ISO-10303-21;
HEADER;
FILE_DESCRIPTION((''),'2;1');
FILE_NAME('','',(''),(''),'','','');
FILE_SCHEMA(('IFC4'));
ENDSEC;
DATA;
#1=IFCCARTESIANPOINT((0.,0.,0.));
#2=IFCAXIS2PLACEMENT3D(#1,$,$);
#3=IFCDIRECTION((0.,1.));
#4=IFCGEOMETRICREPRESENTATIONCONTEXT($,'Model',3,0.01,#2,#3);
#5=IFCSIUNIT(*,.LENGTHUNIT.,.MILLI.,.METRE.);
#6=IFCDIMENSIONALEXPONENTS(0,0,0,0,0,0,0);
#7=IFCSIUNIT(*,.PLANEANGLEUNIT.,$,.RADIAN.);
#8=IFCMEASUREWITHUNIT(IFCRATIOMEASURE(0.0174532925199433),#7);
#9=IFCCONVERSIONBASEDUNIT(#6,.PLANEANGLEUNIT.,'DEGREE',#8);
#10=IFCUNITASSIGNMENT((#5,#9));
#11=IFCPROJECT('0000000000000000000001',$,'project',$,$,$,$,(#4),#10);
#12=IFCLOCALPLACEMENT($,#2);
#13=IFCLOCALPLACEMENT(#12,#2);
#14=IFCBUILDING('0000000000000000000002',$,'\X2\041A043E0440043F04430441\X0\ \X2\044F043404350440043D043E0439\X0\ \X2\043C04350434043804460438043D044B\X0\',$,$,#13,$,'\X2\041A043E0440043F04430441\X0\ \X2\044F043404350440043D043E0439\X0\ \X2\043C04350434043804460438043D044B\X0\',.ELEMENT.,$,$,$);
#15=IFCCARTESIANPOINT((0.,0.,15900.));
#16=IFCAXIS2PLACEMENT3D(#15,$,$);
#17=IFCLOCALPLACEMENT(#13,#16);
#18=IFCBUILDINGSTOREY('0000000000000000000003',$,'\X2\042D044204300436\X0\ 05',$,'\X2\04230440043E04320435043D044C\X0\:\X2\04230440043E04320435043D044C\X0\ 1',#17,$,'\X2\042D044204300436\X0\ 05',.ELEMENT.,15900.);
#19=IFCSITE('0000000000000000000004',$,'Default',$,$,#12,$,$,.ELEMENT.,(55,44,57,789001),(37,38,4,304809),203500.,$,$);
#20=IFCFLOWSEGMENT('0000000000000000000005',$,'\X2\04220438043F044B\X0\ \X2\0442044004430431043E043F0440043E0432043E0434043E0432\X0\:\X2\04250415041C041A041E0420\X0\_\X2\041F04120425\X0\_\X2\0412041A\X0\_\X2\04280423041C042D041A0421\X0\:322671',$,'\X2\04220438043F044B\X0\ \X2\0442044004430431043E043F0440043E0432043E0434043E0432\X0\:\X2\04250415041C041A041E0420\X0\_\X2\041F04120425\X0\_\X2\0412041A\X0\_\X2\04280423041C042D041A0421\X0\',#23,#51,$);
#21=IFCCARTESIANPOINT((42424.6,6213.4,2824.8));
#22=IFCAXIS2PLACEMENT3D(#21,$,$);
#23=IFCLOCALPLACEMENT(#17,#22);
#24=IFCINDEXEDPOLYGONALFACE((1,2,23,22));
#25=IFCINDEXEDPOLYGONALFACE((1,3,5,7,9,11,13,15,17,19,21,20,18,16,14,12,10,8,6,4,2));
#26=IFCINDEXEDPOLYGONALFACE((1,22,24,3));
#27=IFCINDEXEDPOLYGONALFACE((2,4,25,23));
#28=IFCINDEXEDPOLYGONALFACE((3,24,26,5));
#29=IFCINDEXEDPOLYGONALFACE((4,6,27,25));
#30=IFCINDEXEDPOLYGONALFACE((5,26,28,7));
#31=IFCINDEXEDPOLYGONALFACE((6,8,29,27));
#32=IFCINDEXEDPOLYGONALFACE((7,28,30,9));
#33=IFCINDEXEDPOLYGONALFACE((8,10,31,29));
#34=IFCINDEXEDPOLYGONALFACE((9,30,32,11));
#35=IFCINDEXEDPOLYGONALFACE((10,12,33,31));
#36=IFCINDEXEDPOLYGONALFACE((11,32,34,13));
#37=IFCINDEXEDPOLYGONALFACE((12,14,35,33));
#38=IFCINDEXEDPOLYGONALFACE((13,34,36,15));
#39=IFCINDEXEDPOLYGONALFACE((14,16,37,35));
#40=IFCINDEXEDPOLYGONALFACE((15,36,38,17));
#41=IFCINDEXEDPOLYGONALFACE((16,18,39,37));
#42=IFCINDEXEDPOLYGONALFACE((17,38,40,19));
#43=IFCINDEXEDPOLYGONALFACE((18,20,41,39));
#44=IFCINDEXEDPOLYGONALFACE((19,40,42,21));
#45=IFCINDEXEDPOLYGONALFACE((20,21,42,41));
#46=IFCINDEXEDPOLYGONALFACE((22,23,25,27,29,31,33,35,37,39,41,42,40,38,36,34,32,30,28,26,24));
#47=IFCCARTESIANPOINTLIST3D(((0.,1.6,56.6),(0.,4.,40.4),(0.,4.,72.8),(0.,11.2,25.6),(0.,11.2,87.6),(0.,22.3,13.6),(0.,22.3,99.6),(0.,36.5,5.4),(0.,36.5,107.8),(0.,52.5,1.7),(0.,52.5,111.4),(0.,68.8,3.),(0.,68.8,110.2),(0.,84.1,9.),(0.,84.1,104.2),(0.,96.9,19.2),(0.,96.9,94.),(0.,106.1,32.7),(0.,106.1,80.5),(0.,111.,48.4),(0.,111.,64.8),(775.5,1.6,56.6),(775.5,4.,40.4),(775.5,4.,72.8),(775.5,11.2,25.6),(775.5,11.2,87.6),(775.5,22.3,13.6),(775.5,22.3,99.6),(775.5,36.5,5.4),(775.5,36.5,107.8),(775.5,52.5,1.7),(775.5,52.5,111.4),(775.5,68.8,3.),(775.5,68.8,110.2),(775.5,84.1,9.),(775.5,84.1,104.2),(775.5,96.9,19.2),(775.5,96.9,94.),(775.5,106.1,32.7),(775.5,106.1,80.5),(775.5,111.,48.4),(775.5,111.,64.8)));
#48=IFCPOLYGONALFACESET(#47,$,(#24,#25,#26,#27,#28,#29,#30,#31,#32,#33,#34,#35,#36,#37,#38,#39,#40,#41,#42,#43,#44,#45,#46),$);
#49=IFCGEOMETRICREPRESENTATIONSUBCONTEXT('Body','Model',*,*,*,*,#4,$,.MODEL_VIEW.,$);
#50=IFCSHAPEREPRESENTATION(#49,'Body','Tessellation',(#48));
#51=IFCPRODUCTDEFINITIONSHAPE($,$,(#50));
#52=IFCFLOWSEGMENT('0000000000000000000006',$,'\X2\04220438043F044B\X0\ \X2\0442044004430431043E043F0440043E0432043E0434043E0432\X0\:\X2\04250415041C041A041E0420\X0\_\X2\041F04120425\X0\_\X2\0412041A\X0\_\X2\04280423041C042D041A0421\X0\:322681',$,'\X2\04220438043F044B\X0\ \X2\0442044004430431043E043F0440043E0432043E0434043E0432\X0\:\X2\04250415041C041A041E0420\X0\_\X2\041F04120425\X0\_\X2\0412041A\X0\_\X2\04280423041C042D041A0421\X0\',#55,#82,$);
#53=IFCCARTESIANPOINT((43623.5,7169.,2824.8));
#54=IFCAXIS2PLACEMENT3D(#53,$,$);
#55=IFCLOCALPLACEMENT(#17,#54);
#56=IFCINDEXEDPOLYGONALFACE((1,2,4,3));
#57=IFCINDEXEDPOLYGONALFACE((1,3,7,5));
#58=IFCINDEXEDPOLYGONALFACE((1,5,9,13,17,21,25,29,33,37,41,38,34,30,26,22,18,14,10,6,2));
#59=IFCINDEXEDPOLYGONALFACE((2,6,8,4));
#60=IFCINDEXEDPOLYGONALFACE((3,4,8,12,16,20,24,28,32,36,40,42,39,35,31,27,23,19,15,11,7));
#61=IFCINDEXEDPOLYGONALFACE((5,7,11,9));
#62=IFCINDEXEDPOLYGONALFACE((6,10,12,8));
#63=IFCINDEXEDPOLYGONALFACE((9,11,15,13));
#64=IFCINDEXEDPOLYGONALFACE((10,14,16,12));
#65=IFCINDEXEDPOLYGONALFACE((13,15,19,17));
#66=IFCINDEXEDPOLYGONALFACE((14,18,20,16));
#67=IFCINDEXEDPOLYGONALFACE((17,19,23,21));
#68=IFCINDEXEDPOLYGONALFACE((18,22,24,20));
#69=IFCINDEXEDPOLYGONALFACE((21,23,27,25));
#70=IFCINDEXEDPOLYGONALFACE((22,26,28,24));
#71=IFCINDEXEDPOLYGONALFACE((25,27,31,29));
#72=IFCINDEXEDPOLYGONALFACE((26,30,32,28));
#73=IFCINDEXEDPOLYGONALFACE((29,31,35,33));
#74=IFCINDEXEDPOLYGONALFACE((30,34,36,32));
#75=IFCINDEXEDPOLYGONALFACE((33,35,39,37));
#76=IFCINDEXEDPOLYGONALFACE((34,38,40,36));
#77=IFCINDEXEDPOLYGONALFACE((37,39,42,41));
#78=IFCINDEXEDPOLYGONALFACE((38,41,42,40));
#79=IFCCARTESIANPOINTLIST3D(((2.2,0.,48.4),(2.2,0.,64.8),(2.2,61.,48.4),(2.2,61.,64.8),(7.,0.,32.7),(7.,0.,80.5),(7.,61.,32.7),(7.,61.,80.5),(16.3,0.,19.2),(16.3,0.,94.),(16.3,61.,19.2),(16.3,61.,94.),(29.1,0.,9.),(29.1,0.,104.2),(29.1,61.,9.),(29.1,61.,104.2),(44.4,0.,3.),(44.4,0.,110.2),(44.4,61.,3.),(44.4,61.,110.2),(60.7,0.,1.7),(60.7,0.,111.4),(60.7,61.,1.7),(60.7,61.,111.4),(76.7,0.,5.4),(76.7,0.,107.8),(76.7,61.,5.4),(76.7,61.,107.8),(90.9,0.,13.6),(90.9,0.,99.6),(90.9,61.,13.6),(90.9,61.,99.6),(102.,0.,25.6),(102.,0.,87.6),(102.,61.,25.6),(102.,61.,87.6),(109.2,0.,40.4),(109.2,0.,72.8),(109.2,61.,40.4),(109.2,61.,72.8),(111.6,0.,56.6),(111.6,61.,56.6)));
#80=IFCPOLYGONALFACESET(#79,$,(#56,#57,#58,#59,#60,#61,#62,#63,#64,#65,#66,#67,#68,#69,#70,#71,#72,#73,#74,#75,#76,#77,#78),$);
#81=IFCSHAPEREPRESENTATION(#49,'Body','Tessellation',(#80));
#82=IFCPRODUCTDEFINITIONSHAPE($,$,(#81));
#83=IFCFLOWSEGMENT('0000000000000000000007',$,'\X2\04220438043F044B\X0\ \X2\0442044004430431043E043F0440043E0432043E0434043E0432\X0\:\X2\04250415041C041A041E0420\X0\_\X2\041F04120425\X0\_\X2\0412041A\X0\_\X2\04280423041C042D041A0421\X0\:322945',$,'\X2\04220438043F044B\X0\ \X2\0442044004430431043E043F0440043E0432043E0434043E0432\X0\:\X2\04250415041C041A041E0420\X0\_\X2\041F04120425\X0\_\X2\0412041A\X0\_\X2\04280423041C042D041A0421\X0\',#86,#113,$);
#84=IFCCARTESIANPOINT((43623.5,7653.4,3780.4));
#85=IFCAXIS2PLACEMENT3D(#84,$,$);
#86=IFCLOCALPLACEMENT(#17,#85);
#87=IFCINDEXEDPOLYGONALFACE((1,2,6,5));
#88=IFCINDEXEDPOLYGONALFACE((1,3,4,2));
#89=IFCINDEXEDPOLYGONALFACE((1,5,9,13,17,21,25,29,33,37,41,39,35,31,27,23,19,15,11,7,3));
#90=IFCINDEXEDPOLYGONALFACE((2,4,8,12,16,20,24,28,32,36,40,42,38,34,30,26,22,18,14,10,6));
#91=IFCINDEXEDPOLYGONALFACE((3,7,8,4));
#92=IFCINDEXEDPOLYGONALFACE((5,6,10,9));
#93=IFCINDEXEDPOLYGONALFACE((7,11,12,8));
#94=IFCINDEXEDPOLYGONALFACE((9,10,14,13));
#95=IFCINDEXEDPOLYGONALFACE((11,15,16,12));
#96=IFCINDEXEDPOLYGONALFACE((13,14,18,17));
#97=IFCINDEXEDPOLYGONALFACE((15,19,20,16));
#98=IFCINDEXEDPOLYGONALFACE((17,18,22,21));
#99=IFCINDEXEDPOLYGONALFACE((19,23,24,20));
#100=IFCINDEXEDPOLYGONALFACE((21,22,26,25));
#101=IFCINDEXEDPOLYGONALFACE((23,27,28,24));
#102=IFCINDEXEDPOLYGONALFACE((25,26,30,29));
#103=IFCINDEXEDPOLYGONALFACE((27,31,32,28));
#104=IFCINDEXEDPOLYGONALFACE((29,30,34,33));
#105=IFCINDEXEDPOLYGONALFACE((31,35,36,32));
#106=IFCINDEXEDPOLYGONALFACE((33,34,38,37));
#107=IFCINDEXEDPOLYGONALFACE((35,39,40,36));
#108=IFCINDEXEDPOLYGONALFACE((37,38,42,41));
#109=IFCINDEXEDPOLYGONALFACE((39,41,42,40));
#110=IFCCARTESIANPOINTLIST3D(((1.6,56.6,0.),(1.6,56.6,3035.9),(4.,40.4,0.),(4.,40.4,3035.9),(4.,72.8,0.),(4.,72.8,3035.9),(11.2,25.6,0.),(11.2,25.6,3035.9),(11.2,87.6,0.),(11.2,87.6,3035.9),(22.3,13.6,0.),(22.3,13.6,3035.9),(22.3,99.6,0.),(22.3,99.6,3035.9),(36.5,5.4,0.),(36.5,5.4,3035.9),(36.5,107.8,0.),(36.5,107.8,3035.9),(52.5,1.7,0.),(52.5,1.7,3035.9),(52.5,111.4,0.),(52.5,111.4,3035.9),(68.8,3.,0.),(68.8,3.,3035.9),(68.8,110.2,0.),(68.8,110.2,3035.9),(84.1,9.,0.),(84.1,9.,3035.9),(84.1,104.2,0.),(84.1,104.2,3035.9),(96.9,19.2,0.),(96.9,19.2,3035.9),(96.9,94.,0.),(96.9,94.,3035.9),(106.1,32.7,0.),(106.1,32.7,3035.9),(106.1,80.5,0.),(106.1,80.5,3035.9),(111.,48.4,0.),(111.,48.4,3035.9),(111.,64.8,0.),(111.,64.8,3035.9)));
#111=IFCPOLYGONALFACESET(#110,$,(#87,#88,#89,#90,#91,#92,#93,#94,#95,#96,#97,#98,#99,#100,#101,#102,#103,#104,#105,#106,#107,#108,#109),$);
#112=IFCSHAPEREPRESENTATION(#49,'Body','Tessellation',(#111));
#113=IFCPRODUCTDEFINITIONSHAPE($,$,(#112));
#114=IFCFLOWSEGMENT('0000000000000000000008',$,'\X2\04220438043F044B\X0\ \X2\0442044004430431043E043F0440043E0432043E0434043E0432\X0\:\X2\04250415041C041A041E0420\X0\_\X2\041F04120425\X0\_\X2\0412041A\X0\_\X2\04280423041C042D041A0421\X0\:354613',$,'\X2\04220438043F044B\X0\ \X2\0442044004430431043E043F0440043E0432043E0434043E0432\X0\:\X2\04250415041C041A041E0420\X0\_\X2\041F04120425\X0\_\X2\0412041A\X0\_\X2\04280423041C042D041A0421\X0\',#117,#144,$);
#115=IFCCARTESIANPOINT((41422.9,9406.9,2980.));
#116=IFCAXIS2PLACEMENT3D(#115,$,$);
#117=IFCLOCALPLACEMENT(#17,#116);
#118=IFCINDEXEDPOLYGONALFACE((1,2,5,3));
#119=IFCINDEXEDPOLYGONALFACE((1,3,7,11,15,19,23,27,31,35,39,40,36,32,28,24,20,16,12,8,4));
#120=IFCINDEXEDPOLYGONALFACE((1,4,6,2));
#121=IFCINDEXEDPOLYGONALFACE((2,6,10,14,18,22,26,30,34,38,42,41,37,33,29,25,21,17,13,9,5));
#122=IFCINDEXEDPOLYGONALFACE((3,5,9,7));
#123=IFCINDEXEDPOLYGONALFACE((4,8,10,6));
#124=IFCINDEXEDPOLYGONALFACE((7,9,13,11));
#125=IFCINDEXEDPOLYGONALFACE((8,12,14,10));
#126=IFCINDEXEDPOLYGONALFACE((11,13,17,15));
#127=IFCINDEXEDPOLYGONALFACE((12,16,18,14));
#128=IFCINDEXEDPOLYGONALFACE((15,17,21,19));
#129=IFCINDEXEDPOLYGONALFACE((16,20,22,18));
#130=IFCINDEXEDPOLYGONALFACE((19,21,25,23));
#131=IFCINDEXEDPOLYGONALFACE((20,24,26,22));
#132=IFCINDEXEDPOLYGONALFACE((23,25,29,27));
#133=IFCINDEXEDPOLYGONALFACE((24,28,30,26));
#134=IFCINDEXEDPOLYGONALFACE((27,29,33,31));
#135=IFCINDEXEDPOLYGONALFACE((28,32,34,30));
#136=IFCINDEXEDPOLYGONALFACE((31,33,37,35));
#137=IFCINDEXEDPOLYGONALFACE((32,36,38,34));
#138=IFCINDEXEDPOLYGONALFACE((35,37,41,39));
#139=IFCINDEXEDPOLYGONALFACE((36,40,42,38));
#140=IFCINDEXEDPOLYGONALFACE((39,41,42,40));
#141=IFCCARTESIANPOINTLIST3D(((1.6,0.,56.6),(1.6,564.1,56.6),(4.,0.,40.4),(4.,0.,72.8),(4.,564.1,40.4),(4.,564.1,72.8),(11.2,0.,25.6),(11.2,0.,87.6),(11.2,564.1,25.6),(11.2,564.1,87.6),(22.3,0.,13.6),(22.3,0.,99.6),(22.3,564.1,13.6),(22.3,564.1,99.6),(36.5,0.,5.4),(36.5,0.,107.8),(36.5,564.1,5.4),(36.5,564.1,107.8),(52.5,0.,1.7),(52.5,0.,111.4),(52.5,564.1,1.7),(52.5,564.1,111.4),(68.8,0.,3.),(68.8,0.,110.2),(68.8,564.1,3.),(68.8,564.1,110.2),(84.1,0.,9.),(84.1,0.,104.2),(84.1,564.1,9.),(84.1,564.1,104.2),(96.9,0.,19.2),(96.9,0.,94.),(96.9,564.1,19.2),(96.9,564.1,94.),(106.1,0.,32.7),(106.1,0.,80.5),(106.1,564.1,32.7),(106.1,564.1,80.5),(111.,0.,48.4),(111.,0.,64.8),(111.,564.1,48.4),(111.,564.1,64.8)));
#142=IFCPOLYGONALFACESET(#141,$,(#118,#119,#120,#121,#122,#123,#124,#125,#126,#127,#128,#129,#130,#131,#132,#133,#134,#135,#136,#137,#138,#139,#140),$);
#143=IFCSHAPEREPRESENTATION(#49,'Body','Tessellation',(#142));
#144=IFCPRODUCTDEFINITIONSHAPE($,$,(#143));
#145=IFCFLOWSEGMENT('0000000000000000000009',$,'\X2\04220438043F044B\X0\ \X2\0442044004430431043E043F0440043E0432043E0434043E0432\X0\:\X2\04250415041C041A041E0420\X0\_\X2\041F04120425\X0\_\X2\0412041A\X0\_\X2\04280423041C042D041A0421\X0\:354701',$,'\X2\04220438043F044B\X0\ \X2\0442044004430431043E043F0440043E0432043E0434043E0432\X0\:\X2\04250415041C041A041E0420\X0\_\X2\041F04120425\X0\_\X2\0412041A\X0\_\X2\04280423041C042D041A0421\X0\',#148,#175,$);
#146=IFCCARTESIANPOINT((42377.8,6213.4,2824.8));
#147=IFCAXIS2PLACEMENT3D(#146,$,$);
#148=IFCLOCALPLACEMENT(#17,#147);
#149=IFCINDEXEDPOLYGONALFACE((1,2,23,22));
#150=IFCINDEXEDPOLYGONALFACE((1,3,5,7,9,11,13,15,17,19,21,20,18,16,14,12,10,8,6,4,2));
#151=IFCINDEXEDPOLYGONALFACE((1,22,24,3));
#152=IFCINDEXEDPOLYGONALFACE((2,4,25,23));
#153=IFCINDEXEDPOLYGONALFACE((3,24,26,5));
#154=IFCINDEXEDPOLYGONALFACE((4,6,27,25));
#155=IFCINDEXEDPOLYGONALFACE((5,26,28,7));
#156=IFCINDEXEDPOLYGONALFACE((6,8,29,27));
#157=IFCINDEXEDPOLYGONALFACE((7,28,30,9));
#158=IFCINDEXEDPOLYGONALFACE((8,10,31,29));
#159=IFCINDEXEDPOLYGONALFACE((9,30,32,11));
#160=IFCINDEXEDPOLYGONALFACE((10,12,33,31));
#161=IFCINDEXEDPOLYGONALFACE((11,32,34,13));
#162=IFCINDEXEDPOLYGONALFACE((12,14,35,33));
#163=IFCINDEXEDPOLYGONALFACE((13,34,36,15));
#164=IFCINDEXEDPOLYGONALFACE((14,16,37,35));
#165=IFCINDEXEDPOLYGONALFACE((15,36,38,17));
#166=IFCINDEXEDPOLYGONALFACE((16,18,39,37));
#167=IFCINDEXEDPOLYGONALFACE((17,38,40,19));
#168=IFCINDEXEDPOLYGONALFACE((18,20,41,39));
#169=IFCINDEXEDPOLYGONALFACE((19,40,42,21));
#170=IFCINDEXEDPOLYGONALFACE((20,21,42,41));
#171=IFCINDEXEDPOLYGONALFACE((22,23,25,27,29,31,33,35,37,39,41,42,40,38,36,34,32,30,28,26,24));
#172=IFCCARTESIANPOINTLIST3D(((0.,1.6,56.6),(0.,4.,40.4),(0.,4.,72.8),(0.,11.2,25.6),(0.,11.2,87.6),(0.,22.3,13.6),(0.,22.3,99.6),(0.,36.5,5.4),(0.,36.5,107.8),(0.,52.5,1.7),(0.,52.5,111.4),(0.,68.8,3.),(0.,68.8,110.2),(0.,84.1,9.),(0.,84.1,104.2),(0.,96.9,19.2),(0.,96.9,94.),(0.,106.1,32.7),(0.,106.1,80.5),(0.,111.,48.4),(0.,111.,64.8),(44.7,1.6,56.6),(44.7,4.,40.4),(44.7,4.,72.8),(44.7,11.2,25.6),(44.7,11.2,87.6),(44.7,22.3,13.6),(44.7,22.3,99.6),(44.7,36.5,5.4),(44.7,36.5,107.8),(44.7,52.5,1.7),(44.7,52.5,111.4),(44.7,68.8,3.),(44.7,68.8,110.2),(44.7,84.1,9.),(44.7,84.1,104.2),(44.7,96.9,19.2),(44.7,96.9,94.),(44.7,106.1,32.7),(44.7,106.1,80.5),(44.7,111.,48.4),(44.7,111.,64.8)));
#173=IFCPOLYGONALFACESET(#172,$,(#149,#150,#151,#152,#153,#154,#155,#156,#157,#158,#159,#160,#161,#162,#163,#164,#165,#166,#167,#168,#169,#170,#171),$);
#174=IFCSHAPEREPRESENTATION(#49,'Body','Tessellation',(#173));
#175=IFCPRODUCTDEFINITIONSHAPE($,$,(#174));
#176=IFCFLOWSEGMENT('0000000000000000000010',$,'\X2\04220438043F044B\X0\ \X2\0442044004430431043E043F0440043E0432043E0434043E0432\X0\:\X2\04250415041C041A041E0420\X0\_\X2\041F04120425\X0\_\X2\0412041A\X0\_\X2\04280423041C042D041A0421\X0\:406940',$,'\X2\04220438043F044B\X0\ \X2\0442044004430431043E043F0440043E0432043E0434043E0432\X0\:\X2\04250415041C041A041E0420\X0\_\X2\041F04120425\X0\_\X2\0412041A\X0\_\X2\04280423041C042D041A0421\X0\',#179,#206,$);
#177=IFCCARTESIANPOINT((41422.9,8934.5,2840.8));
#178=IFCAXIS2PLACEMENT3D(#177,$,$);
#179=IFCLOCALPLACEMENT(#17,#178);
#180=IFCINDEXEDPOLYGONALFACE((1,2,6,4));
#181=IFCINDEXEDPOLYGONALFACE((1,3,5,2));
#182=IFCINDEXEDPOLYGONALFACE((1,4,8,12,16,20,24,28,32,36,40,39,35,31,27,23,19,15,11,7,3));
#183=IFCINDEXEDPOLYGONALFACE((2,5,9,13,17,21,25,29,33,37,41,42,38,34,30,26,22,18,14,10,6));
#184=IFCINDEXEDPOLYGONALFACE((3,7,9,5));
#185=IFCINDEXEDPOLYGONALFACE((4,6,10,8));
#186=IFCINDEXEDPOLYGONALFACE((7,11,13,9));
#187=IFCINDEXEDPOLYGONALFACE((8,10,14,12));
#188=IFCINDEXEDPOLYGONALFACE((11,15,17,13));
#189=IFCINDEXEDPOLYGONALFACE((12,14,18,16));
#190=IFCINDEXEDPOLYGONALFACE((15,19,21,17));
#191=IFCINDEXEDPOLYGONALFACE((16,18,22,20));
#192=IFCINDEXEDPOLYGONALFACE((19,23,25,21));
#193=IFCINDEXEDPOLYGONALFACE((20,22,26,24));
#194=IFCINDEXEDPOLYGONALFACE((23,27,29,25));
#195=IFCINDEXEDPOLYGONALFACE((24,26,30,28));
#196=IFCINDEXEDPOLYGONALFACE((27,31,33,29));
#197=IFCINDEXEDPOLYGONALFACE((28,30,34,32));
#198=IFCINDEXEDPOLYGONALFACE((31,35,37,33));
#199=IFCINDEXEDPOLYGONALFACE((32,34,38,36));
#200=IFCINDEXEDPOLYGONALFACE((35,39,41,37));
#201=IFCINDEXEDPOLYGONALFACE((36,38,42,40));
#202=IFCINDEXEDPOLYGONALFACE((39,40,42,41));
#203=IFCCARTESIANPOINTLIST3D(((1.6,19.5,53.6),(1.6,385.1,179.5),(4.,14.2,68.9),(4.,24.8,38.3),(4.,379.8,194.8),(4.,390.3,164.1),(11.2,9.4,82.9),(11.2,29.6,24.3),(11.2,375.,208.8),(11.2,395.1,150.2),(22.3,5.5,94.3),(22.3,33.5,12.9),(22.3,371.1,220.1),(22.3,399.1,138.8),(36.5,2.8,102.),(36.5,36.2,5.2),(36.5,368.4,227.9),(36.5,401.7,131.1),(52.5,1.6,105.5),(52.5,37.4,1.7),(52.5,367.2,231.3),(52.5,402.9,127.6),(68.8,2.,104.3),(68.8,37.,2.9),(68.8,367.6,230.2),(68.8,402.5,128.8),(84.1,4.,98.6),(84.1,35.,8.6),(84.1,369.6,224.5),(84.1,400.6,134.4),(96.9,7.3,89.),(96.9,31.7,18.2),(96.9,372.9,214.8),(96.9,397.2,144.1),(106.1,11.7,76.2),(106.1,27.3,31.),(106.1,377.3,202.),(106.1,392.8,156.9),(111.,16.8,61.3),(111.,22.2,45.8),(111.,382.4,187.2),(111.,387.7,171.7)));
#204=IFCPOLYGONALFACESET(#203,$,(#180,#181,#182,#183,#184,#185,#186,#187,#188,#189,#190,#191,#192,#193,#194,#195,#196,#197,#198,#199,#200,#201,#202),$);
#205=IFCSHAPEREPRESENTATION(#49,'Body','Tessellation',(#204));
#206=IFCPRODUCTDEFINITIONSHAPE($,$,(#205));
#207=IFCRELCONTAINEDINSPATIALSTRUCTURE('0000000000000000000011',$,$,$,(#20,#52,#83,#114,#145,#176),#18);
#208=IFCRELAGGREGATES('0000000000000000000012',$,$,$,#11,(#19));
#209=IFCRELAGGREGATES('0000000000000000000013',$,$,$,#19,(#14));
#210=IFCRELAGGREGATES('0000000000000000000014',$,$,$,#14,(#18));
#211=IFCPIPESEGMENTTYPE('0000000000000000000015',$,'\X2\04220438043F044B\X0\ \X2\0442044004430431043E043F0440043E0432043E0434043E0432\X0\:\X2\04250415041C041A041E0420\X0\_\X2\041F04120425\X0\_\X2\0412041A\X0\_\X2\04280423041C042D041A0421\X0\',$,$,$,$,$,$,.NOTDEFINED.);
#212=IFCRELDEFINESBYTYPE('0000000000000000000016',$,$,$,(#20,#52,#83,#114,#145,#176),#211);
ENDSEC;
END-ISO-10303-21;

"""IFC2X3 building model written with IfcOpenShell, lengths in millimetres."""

from ifc_helpers import new_model, entity, si_unit, converted_unit, direction, frame, frame_2d, origin, origin_2d_with_axis, place, context, subcontext, project, spatial, circle, extrude, type_object, element, save


model = new_model("IFC2X3")

# Units and contexts
model_context = context("Model", 3, precision=0.01, world=origin(), true_north=direction((0.0, 1.0)))
body_context = subcontext(model_context, "Body", "Model", "MODEL_VIEW")
ifc_project = project(units=[si_unit("LENGTHUNIT", "METRE", prefix="MILLI"), converted_unit("PLANEANGLEUNIT", "DEGREE", entity("IfcRatioMeasure", 0.0174532925199433), si_unit("PLANEANGLEUNIT", "RADIAN"), dimensions=[0, 0, 0, 0, 0, 0, 0])], contexts=[model_context])

# Site, building, storey
site_placement = place(None, frame((0.0, 0.0, 0.0)))
site = spatial("IfcSite", under=ifc_project, at=site_placement, Name="Default", CompositionType="ELEMENT", RefLatitude=(55, 44, 57, 789001), RefLongitude=(37, 38, 4, 304809), RefElevation=203500.0)
building_placement = place(site_placement, origin())
building = spatial("IfcBuilding", under=site, at=building_placement, Name="Корпус ядерной медицины", LongName="Корпус ядерной медицины", CompositionType="ELEMENT")
storey_placement = place(building_placement, frame((0.0, 0.0, 15900.0)))
storey = spatial("IfcBuildingStorey", under=building, at=storey_placement, Name="Этаж 05", ObjectType="Уровень:Уровень 1", LongName="Этаж 05", CompositionType="ELEMENT", Elevation=15900.0)

# Flow segments
pipe_segment_type = type_object("IfcPipeSegmentType", Name="Типы трубопроводов:ХЕМКОР_ПВХ_ВК_ШУМЭКС", PredefinedType="NOTDEFINED")
flow_segment_1_placement = place(storey_placement, frame((42424.6, 6213.4, 2824.8)))
element("IfcFlowSegment", 1, at=flow_segment_1_placement, inside=storey, type_object=pipe_segment_type, Name="Типы трубопроводов:ХЕМКОР_ПВХ_ВК_ШУМЭКС:322671", ObjectType="Типы трубопроводов:ХЕМКОР_ПВХ_ВК_ШУМЭКС", context=body_context, shape_type="SweptSolid", body=[
    extrude(circle(Radius=55.0, at=origin_2d_with_axis()), frame((0.0, 56.6, 56.6), z_axis=(1.0, 0.0, 0.0), x_axis=(0.0, -1.0, 0.0)), (0.0, 0.0, 1.0), 775.5),
])
flow_segment_2_placement = place(storey_placement, frame((43623.5, 7169.0, 2824.8)))
element("IfcFlowSegment", 2, at=flow_segment_2_placement, inside=storey, type_object=pipe_segment_type, Name="Типы трубопроводов:ХЕМКОР_ПВХ_ВК_ШУМЭКС:322681", ObjectType="Типы трубопроводов:ХЕМКОР_ПВХ_ВК_ШУМЭКС", context=body_context, shape_type="SweptSolid", body=[
    extrude(circle(Radius=55.0, at=origin_2d_with_axis()), frame((56.6, 0.0, 56.6), z_axis=(0.0, 1.0, 0.0), x_axis=(1.0, 0.0, 0.0)), (0.0, 0.0, 1.0), 61.0),
])
flow_segment_3_placement = place(storey_placement, frame((43623.5, 7653.4, 3780.4)))
element("IfcFlowSegment", 3, at=flow_segment_3_placement, inside=storey, type_object=pipe_segment_type, Name="Типы трубопроводов:ХЕМКОР_ПВХ_ВК_ШУМЭКС:322945", ObjectType="Типы трубопроводов:ХЕМКОР_ПВХ_ВК_ШУМЭКС", context=body_context, shape_type="SweptSolid", body=[
    extrude(circle(Radius=55.0, at=origin_2d_with_axis()), frame((56.6, 56.6, 0.0), z_axis=(0.0, 0.0, 1.0), x_axis=(-1.0, 0.0, 0.0)), (0.0, 0.0, 1.0), 3035.9),
])
flow_segment_4_placement = place(storey_placement, frame((41422.9, 9406.9, 2980.0)))
element("IfcFlowSegment", 4, at=flow_segment_4_placement, inside=storey, type_object=pipe_segment_type, Name="Типы трубопроводов:ХЕМКОР_ПВХ_ВК_ШУМЭКС:354613", ObjectType="Типы трубопроводов:ХЕМКОР_ПВХ_ВК_ШУМЭКС", context=body_context, shape_type="SweptSolid", body=[
    extrude(circle(Radius=55.0, at=origin_2d_with_axis()), frame((56.6, 0.0, 56.6), z_axis=(0.0, 1.0, 0.0), x_axis=(-1.0, 0.0, 0.0)), (0.0, 0.0, 1.0), 564.1),
])
flow_segment_5_placement = place(storey_placement, frame((42377.8, 6213.4, 2824.8)))
element("IfcFlowSegment", 5, at=flow_segment_5_placement, inside=storey, type_object=pipe_segment_type, Name="Типы трубопроводов:ХЕМКОР_ПВХ_ВК_ШУМЭКС:354701", ObjectType="Типы трубопроводов:ХЕМКОР_ПВХ_ВК_ШУМЭКС", context=body_context, shape_type="SweptSolid", body=[
    extrude(circle(Radius=55.0, at=origin_2d_with_axis()), frame((0.0, 56.6, 56.6), z_axis=(1.0, 0.0, 0.0), x_axis=(0.0, -1.0, 0.0)), (0.0, 0.0, 1.0), 44.7),
])
flow_segment_6_placement = place(storey_placement, frame((41422.9, 8934.5, 2840.8)))
element("IfcFlowSegment", 6, at=flow_segment_6_placement, inside=storey, type_object=pipe_segment_type, Name="Типы трубопроводов:ХЕМКОР_ПВХ_ВК_ШУМЭКС:406940", ObjectType="Типы трубопроводов:ХЕМКОР_ПВХ_ВК_ШУМЭКС", context=body_context, shape_type="SweptSolid", body=[
    extrude(circle(Radius=55.0, at=frame_2d((0.0, 0.0), x_axis=(1.0, 0.0))), frame((56.6, 19.5, 53.6), z_axis=(0.0, 0.945519, 0.325568), x_axis=(-1.0, 0.0, 0.0)), (0.0, 0.0, 1.0), 386.6),
])

save(model, "model.ifc")
